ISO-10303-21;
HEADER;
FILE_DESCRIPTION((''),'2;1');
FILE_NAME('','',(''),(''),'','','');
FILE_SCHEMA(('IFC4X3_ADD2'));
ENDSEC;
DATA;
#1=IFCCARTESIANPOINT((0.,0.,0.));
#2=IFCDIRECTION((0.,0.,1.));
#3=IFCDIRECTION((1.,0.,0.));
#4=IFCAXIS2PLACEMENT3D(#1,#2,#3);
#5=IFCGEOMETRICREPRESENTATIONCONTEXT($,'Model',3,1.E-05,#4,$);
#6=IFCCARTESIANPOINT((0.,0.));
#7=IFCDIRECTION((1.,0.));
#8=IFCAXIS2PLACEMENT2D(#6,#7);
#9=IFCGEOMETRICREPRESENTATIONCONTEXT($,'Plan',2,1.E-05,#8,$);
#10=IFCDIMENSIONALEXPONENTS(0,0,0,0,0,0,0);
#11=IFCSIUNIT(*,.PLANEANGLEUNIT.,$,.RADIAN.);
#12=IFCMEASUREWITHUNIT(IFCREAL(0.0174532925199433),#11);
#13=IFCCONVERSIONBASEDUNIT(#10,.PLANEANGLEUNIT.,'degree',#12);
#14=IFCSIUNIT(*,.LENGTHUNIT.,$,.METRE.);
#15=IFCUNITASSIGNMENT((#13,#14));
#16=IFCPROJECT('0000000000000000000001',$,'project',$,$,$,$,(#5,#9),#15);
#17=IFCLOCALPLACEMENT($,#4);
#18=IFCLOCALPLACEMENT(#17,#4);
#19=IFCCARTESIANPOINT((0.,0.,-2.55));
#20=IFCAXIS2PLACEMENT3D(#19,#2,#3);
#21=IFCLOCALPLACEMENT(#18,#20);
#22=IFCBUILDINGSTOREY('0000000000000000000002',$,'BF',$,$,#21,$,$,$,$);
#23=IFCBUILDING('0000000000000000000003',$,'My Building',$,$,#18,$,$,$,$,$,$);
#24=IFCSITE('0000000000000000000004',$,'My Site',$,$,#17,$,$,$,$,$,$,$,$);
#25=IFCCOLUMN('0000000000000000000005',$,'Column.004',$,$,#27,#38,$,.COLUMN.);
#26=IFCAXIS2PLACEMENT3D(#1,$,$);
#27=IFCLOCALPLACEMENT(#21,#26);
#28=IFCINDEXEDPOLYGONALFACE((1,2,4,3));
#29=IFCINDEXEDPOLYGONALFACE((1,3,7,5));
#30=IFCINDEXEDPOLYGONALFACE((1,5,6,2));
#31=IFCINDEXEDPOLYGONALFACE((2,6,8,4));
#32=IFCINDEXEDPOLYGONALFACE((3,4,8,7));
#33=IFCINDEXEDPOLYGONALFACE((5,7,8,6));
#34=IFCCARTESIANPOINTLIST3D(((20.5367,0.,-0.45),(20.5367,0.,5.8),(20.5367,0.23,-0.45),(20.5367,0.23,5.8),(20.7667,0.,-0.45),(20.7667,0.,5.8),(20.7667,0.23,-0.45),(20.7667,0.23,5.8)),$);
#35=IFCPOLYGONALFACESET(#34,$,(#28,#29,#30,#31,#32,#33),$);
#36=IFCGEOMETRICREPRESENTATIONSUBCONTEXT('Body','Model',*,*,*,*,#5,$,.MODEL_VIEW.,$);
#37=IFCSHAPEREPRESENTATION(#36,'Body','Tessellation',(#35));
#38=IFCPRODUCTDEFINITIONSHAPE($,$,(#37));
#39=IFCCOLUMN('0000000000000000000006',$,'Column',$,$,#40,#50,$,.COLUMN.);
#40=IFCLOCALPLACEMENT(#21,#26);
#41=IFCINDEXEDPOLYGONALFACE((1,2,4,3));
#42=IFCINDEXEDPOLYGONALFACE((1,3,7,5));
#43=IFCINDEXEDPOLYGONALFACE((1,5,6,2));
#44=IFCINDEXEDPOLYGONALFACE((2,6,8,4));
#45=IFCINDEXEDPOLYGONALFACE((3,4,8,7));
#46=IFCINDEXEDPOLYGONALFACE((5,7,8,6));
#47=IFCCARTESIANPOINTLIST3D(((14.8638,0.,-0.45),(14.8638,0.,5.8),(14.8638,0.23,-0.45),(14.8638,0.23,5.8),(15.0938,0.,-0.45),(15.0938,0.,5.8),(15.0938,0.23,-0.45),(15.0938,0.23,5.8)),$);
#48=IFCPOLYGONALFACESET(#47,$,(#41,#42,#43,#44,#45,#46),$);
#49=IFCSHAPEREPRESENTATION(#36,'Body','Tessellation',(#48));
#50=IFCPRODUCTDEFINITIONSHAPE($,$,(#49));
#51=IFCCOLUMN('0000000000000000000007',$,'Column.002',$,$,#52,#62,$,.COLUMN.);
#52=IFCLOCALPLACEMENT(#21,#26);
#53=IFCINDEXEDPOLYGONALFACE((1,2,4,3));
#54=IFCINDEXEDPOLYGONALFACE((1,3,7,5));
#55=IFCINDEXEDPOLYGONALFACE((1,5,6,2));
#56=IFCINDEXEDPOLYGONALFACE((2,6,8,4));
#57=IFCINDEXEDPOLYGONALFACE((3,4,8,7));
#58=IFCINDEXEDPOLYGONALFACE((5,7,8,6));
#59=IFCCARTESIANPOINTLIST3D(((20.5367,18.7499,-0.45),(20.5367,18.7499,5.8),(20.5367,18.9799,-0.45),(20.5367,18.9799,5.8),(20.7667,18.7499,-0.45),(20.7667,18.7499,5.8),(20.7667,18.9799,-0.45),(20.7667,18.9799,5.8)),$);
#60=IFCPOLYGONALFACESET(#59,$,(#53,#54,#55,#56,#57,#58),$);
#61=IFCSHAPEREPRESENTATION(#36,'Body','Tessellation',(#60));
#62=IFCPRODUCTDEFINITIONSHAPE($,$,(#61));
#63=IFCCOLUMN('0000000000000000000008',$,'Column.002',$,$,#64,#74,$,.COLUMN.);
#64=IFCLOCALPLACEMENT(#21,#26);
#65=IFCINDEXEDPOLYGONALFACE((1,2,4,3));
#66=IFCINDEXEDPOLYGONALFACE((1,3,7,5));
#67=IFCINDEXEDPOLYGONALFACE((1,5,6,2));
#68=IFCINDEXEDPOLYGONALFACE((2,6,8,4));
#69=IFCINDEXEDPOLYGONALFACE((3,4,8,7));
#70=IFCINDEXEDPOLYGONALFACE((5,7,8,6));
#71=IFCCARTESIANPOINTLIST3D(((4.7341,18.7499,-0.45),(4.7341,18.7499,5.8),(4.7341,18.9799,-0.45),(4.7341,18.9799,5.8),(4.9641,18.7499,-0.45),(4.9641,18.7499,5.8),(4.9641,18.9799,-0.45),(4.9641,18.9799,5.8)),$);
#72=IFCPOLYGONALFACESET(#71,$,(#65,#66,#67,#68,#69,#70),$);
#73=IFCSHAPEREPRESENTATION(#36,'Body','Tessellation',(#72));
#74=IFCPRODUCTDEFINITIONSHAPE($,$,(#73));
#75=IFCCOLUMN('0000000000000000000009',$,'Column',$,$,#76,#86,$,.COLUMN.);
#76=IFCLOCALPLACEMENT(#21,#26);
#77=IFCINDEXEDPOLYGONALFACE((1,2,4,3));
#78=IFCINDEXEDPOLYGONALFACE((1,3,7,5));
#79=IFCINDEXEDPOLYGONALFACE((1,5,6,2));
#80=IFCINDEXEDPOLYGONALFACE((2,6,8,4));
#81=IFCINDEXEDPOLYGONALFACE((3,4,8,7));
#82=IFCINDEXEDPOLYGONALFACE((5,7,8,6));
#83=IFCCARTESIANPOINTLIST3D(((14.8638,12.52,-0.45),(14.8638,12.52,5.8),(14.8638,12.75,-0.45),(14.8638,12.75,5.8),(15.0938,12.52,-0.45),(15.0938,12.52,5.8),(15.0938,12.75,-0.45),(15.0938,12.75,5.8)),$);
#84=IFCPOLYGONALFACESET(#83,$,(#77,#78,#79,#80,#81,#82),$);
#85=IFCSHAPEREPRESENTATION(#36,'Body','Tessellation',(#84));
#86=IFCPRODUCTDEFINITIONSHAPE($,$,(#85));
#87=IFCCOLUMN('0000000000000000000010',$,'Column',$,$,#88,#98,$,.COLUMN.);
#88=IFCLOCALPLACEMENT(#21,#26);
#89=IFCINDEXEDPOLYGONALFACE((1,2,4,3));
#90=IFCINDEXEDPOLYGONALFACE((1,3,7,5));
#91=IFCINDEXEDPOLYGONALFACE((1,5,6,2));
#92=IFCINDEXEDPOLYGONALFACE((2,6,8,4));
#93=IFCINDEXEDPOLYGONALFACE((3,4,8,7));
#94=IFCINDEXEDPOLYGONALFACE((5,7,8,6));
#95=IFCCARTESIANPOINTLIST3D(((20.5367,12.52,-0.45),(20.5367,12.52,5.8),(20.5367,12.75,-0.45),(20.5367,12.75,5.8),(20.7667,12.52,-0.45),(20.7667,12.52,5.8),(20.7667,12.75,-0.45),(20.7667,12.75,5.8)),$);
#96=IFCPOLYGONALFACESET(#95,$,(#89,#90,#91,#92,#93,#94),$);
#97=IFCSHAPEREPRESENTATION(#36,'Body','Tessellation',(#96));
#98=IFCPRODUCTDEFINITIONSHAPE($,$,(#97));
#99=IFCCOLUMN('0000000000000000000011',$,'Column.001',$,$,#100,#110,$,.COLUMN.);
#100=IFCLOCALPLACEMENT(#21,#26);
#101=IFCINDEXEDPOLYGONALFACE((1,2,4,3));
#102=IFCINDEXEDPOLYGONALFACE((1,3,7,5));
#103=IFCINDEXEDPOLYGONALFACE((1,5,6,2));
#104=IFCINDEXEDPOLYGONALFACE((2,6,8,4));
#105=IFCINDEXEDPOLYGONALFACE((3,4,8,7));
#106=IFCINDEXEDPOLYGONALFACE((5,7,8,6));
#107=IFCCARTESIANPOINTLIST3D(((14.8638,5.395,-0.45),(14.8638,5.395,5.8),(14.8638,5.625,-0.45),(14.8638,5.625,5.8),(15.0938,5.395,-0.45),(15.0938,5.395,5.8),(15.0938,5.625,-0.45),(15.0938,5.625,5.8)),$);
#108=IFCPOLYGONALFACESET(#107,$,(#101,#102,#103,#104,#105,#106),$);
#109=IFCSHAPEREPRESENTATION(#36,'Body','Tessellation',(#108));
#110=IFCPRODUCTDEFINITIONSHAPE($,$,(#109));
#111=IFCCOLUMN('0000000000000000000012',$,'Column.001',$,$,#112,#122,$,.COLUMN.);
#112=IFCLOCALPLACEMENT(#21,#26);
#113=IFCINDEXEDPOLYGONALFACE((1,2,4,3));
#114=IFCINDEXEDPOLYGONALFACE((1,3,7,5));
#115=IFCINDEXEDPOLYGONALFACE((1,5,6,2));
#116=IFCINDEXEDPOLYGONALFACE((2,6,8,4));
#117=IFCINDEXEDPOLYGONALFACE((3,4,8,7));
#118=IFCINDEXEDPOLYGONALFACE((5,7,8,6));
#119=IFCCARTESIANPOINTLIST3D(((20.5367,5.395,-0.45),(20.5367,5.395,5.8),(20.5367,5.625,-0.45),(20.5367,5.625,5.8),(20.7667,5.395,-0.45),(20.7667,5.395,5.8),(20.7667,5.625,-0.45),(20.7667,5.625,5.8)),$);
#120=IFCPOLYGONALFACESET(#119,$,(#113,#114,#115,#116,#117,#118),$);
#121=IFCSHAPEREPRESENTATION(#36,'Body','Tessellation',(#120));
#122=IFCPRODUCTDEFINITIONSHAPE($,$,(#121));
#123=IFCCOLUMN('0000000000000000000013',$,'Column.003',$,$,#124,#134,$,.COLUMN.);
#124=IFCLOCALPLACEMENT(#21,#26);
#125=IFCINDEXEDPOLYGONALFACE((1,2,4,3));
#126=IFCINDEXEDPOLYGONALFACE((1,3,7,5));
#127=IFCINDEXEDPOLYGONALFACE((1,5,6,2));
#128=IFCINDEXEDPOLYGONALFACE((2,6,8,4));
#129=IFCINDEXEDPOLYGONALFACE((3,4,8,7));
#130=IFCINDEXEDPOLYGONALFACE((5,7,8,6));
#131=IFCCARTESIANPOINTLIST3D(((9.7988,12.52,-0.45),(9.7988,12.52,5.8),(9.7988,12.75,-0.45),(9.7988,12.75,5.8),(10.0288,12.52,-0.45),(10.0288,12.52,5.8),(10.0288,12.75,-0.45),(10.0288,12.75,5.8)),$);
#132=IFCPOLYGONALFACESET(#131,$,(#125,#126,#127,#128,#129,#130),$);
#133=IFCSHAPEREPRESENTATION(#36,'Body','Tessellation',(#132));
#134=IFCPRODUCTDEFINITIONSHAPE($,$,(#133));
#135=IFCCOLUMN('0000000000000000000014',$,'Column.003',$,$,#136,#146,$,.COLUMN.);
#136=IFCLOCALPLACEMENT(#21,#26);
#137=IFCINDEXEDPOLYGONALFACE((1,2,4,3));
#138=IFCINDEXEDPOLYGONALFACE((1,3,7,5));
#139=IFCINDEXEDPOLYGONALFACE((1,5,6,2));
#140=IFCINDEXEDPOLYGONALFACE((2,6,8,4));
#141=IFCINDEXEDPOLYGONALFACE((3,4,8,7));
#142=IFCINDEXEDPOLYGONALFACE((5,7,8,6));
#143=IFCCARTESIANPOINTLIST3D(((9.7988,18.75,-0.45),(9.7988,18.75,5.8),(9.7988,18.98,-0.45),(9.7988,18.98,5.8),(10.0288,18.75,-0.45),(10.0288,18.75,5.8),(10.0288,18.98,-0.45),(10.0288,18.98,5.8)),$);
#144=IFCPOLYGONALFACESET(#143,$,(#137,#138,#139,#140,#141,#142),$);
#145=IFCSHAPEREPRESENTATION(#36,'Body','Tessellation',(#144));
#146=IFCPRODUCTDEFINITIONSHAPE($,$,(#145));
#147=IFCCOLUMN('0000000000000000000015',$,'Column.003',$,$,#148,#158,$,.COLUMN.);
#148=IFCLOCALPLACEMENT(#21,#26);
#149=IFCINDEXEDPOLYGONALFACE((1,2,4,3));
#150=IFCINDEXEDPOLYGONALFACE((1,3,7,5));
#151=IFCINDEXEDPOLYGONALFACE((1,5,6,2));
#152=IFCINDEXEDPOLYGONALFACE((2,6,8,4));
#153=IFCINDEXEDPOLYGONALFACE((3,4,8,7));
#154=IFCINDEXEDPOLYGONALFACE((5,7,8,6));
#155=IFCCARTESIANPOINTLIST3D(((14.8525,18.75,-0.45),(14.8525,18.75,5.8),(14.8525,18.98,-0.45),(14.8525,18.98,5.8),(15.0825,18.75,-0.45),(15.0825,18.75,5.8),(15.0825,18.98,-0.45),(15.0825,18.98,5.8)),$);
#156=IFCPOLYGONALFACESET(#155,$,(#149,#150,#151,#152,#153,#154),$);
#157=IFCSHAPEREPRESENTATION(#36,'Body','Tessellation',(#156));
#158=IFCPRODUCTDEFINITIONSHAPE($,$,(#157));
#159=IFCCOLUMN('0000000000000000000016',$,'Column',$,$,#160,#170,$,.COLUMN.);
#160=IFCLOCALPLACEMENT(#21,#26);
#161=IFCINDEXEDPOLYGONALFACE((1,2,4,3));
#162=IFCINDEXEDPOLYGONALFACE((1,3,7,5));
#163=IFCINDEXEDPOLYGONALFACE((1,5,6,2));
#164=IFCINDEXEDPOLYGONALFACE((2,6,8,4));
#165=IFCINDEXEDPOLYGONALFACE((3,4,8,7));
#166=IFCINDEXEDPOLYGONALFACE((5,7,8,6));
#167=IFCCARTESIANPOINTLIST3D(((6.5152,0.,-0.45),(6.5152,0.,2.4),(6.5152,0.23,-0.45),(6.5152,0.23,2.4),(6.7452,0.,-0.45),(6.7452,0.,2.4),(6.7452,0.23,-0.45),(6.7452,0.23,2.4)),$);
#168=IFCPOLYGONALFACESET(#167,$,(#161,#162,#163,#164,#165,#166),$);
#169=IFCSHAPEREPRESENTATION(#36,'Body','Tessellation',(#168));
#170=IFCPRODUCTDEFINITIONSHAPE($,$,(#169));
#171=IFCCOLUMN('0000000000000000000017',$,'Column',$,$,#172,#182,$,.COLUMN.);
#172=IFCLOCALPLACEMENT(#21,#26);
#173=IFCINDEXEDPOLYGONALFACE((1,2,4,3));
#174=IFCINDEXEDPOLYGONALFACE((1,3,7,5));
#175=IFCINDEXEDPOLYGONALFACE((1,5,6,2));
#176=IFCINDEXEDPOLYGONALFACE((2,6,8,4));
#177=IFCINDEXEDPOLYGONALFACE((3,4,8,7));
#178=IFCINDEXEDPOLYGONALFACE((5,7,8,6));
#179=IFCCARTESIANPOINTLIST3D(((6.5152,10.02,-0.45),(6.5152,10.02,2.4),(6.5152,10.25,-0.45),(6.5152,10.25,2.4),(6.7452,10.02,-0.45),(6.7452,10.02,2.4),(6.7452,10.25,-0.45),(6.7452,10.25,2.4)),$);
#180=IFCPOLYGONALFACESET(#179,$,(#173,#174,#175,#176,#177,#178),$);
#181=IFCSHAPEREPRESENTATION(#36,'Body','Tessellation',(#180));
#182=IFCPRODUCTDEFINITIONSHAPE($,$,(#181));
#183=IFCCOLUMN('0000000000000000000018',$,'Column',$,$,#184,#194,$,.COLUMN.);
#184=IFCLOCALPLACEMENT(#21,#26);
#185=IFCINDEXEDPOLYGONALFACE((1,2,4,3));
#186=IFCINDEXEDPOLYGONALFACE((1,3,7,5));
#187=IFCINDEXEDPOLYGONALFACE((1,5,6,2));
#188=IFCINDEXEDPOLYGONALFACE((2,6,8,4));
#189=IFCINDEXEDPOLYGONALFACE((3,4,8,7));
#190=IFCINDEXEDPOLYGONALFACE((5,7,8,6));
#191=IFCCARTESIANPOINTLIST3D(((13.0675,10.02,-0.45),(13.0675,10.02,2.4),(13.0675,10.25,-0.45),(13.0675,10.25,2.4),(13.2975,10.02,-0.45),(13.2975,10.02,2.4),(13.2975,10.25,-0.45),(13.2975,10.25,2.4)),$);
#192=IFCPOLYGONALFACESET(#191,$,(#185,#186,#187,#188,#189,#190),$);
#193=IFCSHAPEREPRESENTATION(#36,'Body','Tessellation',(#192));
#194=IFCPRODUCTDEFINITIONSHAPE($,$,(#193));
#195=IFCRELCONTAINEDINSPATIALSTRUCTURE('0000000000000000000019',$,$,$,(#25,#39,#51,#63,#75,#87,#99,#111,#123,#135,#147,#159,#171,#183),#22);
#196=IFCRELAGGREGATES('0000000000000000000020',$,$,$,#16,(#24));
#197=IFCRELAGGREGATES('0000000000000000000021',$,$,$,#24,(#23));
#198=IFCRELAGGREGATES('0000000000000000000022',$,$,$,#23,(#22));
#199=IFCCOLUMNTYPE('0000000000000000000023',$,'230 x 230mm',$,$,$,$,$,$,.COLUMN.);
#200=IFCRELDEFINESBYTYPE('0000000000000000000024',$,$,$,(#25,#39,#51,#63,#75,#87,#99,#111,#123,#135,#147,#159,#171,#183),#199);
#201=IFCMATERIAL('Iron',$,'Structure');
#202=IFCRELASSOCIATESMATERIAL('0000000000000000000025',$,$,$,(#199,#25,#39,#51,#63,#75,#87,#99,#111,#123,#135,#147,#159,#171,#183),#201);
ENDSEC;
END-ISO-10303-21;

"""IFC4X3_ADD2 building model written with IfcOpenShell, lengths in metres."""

from ifc_helpers import new_model, entity, si_unit, converted_unit, frame, origin_with_axes, origin_2d_with_axis, place, context, subcontext, project, spatial, rectangle, extrude, material, material_profile, profile_set, profile_usage, type_object, element, save


model = new_model("IFC4X3_ADD2")

# Units and contexts
model_context = context("Model", 3, precision=1e-05, world=origin_with_axes())
plan_context = context("Plan", 2, precision=1e-05, world=origin_2d_with_axis())
body_context_1 = subcontext(model_context, "Body", "Model", "MODEL_VIEW")
ifc_project = project(units=[converted_unit("PLANEANGLEUNIT", "degree", entity("IfcReal", 0.0174532925199433), si_unit("PLANEANGLEUNIT", "RADIAN"), dimensions=[0, 0, 0, 0, 0, 0, 0]), si_unit("LENGTHUNIT", "METRE")], contexts=[model_context, plan_context])

# Site, building, storey
site_placement = place(None, origin_with_axes())
site = spatial("IfcSite", under=ifc_project, at=site_placement, Name="My Site")
building_placement = place(site_placement, origin_with_axes())
building = spatial("IfcBuilding", under=site, at=building_placement, Name="My Building")
storey_placement = place(building_placement, frame((0.0, 0.0, -2.55), z_axis=(0.0, 0.0, 1.0), x_axis=(1.0, 0.0, 0.0)))
storey = spatial("IfcBuildingStorey", under=building, at=storey_placement, Name="BF")

# Columns
ifc_material_1 = material(Name="Iron", Category="Structure")
ifc_material_profile = material_profile(ifc_material_1, rectangle(XDim=0.23, YDim=0.23))
ifc_profile_set = profile_set([ifc_material_profile])
ifc_profile_usage_1 = profile_usage(ifc_profile_set)
column_type = type_object("IfcColumnType", Name="230 x 230mm", PredefinedType="COLUMN", material=ifc_profile_set)
column_1_placement = place(storey_placement, frame((20.6517, 0.115, -0.45), z_axis=(0.0, 0.0, 1.0), x_axis=(1.0, 0.0, 0.0)))
element("IfcColumn", 1, at=column_1_placement, inside=storey, type_object=column_type, material=ifc_profile_usage_1, Name="Column.004", PredefinedType="COLUMN", context=body_context_1, shape_type="SweptSolid", body=[
    extrude(rectangle(XDim=0.23, YDim=0.23), origin_with_axes(), (0.0, 0.0, 1.0), 6.25),
])
ifc_profile_usage_2 = profile_usage(ifc_profile_set)
column_2_placement = place(storey_placement, frame((14.9788, 0.115, -0.45), z_axis=(0.0, 0.0, 1.0), x_axis=(1.0, 0.0, 0.0)))
element("IfcColumn", 2, at=column_2_placement, inside=storey, type_object=column_type, material=ifc_profile_usage_2, Name="Column", PredefinedType="COLUMN", context=body_context_1, shape_type="SweptSolid", body=[
    extrude(rectangle(XDim=0.23, YDim=0.23), origin_with_axes(), (0.0, 0.0, 1.0), 6.25),
])
ifc_profile_usage_3 = profile_usage(ifc_profile_set)
column_3_placement = place(storey_placement, frame((20.6517, 18.8649, -0.45), z_axis=(0.0, 0.0, 1.0), x_axis=(1.0, 0.0, 0.0)))
element("IfcColumn", 3, at=column_3_placement, inside=storey, type_object=column_type, material=ifc_profile_usage_3, Name="Column.002", PredefinedType="COLUMN", context=body_context_1, shape_type="SweptSolid", body=[
    extrude(rectangle(XDim=0.23, YDim=0.23), origin_with_axes(), (0.0, 0.0, 1.0), 6.25),
])
ifc_profile_usage_4 = profile_usage(ifc_profile_set)
column_4_placement = place(storey_placement, frame((4.8491, 18.8649, -0.45), z_axis=(0.0, 0.0, 1.0), x_axis=(1.0, 0.0, 0.0)))
element("IfcColumn", 4, at=column_4_placement, inside=storey, type_object=column_type, material=ifc_profile_usage_4, Name="Column.002", PredefinedType="COLUMN", context=body_context_1, shape_type="SweptSolid", body=[
    extrude(rectangle(XDim=0.23, YDim=0.23), origin_with_axes(), (0.0, 0.0, 1.0), 6.25),
])
ifc_profile_usage_5 = profile_usage(ifc_profile_set)
column_5_placement = place(storey_placement, frame((14.9788, 12.635, -0.45), z_axis=(0.0, 0.0, 1.0), x_axis=(1.0, 0.0, 0.0)))
element("IfcColumn", 5, at=column_5_placement, inside=storey, type_object=column_type, material=ifc_profile_usage_5, Name="Column", PredefinedType="COLUMN", context=body_context_1, shape_type="SweptSolid", body=[
    extrude(rectangle(XDim=0.23, YDim=0.23), origin_with_axes(), (0.0, 0.0, 1.0), 6.25),
])
ifc_profile_usage_6 = profile_usage(ifc_profile_set)
column_6_placement = place(storey_placement, frame((20.6517, 12.635, -0.45), z_axis=(0.0, 0.0, 1.0), x_axis=(1.0, 0.0, 0.0)))
element("IfcColumn", 6, at=column_6_placement, inside=storey, type_object=column_type, material=ifc_profile_usage_6, Name="Column", PredefinedType="COLUMN", context=body_context_1, shape_type="SweptSolid", body=[
    extrude(rectangle(XDim=0.23, YDim=0.23), origin_with_axes(), (0.0, 0.0, 1.0), 6.25),
])
ifc_profile_usage_7 = profile_usage(ifc_profile_set)
column_7_placement = place(storey_placement, frame((14.9788, 5.51, -0.45), z_axis=(0.0, 0.0, 1.0), x_axis=(1.0, 0.0, 0.0)))
element("IfcColumn", 7, at=column_7_placement, inside=storey, type_object=column_type, material=ifc_profile_usage_7, Name="Column.001", PredefinedType="COLUMN", context=body_context_1, shape_type="SweptSolid", body=[
    extrude(rectangle(XDim=0.23, YDim=0.23), origin_with_axes(), (0.0, 0.0, 1.0), 6.25),
])
ifc_profile_usage_8 = profile_usage(ifc_profile_set)
column_8_placement = place(storey_placement, frame((20.6517, 5.51, -0.45), z_axis=(0.0, 0.0, 1.0), x_axis=(1.0, 0.0, 0.0)))
element("IfcColumn", 8, at=column_8_placement, inside=storey, type_object=column_type, material=ifc_profile_usage_8, Name="Column.001", PredefinedType="COLUMN", context=body_context_1, shape_type="SweptSolid", body=[
    extrude(rectangle(XDim=0.23, YDim=0.23), origin_with_axes(), (0.0, 0.0, 1.0), 6.25),
])
ifc_profile_usage_9 = profile_usage(ifc_profile_set)
column_9_placement = place(storey_placement, frame((9.9138, 12.635, -0.45), z_axis=(0.0, 0.0, 1.0), x_axis=(1.0, 0.0, 0.0)))
element("IfcColumn", 9, at=column_9_placement, inside=storey, type_object=column_type, material=ifc_profile_usage_9, Name="Column.003", PredefinedType="COLUMN", context=body_context_1, shape_type="SweptSolid", body=[
    extrude(rectangle(XDim=0.23, YDim=0.23), origin_with_axes(), (0.0, 0.0, 1.0), 6.25),
])
ifc_profile_usage_10 = profile_usage(ifc_profile_set)
column_10_placement = place(storey_placement, frame((9.9138, 18.865, -0.45), z_axis=(0.0, 0.0, 1.0), x_axis=(1.0, 0.0, 0.0)))
element("IfcColumn", 10, at=column_10_placement, inside=storey, type_object=column_type, material=ifc_profile_usage_10, Name="Column.003", PredefinedType="COLUMN", context=body_context_1, shape_type="SweptSolid", body=[
    extrude(rectangle(XDim=0.23, YDim=0.23), origin_with_axes(), (0.0, 0.0, 1.0), 6.25),
])
ifc_profile_usage_11 = profile_usage(ifc_profile_set)
column_11_placement = place(storey_placement, frame((14.9675, 18.865, -0.45), z_axis=(0.0, 0.0, 1.0), x_axis=(1.0, 0.0, 0.0)))
element("IfcColumn", 11, at=column_11_placement, inside=storey, type_object=column_type, material=ifc_profile_usage_11, Name="Column.003", PredefinedType="COLUMN", context=body_context_1, shape_type="SweptSolid", body=[
    extrude(rectangle(XDim=0.23, YDim=0.23), origin_with_axes(), (0.0, 0.0, 1.0), 6.25),
])
ifc_profile_usage_12 = profile_usage(ifc_profile_set)
column_12_placement = place(storey_placement, frame((6.6302, 0.115, -0.45), z_axis=(0.0, 0.0, 1.0), x_axis=(1.0, 0.0, 0.0)))
element("IfcColumn", 12, at=column_12_placement, inside=storey, type_object=column_type, material=ifc_profile_usage_12, Name="Column", PredefinedType="COLUMN", context=body_context_1, shape_type="SweptSolid", body=[
    extrude(rectangle(XDim=0.23, YDim=0.23), origin_with_axes(), (0.0, 0.0, 1.0), 2.85),
])
ifc_profile_usage_13 = profile_usage(ifc_profile_set)
column_13_placement = place(storey_placement, frame((6.6302, 10.135, -0.45), z_axis=(0.0, 0.0, 1.0), x_axis=(1.0, 0.0, 0.0)))
element("IfcColumn", 13, at=column_13_placement, inside=storey, type_object=column_type, material=ifc_profile_usage_13, Name="Column", PredefinedType="COLUMN", context=body_context_1, shape_type="SweptSolid", body=[
    extrude(rectangle(XDim=0.23, YDim=0.23), origin_with_axes(), (0.0, 0.0, 1.0), 2.85),
])
ifc_profile_usage_14 = profile_usage(ifc_profile_set)
column_14_placement = place(storey_placement, frame((13.1825, 10.135, -0.45), z_axis=(0.0, 0.0, 1.0), x_axis=(1.0, 0.0, 0.0)))
element("IfcColumn", 14, at=column_14_placement, inside=storey, type_object=column_type, material=ifc_profile_usage_14, Name="Column", PredefinedType="COLUMN", context=body_context_1, shape_type="SweptSolid", body=[
    extrude(rectangle(XDim=0.23, YDim=0.23), origin_with_axes(), (0.0, 0.0, 1.0), 2.85),
])

save(model, "model.ifc")
